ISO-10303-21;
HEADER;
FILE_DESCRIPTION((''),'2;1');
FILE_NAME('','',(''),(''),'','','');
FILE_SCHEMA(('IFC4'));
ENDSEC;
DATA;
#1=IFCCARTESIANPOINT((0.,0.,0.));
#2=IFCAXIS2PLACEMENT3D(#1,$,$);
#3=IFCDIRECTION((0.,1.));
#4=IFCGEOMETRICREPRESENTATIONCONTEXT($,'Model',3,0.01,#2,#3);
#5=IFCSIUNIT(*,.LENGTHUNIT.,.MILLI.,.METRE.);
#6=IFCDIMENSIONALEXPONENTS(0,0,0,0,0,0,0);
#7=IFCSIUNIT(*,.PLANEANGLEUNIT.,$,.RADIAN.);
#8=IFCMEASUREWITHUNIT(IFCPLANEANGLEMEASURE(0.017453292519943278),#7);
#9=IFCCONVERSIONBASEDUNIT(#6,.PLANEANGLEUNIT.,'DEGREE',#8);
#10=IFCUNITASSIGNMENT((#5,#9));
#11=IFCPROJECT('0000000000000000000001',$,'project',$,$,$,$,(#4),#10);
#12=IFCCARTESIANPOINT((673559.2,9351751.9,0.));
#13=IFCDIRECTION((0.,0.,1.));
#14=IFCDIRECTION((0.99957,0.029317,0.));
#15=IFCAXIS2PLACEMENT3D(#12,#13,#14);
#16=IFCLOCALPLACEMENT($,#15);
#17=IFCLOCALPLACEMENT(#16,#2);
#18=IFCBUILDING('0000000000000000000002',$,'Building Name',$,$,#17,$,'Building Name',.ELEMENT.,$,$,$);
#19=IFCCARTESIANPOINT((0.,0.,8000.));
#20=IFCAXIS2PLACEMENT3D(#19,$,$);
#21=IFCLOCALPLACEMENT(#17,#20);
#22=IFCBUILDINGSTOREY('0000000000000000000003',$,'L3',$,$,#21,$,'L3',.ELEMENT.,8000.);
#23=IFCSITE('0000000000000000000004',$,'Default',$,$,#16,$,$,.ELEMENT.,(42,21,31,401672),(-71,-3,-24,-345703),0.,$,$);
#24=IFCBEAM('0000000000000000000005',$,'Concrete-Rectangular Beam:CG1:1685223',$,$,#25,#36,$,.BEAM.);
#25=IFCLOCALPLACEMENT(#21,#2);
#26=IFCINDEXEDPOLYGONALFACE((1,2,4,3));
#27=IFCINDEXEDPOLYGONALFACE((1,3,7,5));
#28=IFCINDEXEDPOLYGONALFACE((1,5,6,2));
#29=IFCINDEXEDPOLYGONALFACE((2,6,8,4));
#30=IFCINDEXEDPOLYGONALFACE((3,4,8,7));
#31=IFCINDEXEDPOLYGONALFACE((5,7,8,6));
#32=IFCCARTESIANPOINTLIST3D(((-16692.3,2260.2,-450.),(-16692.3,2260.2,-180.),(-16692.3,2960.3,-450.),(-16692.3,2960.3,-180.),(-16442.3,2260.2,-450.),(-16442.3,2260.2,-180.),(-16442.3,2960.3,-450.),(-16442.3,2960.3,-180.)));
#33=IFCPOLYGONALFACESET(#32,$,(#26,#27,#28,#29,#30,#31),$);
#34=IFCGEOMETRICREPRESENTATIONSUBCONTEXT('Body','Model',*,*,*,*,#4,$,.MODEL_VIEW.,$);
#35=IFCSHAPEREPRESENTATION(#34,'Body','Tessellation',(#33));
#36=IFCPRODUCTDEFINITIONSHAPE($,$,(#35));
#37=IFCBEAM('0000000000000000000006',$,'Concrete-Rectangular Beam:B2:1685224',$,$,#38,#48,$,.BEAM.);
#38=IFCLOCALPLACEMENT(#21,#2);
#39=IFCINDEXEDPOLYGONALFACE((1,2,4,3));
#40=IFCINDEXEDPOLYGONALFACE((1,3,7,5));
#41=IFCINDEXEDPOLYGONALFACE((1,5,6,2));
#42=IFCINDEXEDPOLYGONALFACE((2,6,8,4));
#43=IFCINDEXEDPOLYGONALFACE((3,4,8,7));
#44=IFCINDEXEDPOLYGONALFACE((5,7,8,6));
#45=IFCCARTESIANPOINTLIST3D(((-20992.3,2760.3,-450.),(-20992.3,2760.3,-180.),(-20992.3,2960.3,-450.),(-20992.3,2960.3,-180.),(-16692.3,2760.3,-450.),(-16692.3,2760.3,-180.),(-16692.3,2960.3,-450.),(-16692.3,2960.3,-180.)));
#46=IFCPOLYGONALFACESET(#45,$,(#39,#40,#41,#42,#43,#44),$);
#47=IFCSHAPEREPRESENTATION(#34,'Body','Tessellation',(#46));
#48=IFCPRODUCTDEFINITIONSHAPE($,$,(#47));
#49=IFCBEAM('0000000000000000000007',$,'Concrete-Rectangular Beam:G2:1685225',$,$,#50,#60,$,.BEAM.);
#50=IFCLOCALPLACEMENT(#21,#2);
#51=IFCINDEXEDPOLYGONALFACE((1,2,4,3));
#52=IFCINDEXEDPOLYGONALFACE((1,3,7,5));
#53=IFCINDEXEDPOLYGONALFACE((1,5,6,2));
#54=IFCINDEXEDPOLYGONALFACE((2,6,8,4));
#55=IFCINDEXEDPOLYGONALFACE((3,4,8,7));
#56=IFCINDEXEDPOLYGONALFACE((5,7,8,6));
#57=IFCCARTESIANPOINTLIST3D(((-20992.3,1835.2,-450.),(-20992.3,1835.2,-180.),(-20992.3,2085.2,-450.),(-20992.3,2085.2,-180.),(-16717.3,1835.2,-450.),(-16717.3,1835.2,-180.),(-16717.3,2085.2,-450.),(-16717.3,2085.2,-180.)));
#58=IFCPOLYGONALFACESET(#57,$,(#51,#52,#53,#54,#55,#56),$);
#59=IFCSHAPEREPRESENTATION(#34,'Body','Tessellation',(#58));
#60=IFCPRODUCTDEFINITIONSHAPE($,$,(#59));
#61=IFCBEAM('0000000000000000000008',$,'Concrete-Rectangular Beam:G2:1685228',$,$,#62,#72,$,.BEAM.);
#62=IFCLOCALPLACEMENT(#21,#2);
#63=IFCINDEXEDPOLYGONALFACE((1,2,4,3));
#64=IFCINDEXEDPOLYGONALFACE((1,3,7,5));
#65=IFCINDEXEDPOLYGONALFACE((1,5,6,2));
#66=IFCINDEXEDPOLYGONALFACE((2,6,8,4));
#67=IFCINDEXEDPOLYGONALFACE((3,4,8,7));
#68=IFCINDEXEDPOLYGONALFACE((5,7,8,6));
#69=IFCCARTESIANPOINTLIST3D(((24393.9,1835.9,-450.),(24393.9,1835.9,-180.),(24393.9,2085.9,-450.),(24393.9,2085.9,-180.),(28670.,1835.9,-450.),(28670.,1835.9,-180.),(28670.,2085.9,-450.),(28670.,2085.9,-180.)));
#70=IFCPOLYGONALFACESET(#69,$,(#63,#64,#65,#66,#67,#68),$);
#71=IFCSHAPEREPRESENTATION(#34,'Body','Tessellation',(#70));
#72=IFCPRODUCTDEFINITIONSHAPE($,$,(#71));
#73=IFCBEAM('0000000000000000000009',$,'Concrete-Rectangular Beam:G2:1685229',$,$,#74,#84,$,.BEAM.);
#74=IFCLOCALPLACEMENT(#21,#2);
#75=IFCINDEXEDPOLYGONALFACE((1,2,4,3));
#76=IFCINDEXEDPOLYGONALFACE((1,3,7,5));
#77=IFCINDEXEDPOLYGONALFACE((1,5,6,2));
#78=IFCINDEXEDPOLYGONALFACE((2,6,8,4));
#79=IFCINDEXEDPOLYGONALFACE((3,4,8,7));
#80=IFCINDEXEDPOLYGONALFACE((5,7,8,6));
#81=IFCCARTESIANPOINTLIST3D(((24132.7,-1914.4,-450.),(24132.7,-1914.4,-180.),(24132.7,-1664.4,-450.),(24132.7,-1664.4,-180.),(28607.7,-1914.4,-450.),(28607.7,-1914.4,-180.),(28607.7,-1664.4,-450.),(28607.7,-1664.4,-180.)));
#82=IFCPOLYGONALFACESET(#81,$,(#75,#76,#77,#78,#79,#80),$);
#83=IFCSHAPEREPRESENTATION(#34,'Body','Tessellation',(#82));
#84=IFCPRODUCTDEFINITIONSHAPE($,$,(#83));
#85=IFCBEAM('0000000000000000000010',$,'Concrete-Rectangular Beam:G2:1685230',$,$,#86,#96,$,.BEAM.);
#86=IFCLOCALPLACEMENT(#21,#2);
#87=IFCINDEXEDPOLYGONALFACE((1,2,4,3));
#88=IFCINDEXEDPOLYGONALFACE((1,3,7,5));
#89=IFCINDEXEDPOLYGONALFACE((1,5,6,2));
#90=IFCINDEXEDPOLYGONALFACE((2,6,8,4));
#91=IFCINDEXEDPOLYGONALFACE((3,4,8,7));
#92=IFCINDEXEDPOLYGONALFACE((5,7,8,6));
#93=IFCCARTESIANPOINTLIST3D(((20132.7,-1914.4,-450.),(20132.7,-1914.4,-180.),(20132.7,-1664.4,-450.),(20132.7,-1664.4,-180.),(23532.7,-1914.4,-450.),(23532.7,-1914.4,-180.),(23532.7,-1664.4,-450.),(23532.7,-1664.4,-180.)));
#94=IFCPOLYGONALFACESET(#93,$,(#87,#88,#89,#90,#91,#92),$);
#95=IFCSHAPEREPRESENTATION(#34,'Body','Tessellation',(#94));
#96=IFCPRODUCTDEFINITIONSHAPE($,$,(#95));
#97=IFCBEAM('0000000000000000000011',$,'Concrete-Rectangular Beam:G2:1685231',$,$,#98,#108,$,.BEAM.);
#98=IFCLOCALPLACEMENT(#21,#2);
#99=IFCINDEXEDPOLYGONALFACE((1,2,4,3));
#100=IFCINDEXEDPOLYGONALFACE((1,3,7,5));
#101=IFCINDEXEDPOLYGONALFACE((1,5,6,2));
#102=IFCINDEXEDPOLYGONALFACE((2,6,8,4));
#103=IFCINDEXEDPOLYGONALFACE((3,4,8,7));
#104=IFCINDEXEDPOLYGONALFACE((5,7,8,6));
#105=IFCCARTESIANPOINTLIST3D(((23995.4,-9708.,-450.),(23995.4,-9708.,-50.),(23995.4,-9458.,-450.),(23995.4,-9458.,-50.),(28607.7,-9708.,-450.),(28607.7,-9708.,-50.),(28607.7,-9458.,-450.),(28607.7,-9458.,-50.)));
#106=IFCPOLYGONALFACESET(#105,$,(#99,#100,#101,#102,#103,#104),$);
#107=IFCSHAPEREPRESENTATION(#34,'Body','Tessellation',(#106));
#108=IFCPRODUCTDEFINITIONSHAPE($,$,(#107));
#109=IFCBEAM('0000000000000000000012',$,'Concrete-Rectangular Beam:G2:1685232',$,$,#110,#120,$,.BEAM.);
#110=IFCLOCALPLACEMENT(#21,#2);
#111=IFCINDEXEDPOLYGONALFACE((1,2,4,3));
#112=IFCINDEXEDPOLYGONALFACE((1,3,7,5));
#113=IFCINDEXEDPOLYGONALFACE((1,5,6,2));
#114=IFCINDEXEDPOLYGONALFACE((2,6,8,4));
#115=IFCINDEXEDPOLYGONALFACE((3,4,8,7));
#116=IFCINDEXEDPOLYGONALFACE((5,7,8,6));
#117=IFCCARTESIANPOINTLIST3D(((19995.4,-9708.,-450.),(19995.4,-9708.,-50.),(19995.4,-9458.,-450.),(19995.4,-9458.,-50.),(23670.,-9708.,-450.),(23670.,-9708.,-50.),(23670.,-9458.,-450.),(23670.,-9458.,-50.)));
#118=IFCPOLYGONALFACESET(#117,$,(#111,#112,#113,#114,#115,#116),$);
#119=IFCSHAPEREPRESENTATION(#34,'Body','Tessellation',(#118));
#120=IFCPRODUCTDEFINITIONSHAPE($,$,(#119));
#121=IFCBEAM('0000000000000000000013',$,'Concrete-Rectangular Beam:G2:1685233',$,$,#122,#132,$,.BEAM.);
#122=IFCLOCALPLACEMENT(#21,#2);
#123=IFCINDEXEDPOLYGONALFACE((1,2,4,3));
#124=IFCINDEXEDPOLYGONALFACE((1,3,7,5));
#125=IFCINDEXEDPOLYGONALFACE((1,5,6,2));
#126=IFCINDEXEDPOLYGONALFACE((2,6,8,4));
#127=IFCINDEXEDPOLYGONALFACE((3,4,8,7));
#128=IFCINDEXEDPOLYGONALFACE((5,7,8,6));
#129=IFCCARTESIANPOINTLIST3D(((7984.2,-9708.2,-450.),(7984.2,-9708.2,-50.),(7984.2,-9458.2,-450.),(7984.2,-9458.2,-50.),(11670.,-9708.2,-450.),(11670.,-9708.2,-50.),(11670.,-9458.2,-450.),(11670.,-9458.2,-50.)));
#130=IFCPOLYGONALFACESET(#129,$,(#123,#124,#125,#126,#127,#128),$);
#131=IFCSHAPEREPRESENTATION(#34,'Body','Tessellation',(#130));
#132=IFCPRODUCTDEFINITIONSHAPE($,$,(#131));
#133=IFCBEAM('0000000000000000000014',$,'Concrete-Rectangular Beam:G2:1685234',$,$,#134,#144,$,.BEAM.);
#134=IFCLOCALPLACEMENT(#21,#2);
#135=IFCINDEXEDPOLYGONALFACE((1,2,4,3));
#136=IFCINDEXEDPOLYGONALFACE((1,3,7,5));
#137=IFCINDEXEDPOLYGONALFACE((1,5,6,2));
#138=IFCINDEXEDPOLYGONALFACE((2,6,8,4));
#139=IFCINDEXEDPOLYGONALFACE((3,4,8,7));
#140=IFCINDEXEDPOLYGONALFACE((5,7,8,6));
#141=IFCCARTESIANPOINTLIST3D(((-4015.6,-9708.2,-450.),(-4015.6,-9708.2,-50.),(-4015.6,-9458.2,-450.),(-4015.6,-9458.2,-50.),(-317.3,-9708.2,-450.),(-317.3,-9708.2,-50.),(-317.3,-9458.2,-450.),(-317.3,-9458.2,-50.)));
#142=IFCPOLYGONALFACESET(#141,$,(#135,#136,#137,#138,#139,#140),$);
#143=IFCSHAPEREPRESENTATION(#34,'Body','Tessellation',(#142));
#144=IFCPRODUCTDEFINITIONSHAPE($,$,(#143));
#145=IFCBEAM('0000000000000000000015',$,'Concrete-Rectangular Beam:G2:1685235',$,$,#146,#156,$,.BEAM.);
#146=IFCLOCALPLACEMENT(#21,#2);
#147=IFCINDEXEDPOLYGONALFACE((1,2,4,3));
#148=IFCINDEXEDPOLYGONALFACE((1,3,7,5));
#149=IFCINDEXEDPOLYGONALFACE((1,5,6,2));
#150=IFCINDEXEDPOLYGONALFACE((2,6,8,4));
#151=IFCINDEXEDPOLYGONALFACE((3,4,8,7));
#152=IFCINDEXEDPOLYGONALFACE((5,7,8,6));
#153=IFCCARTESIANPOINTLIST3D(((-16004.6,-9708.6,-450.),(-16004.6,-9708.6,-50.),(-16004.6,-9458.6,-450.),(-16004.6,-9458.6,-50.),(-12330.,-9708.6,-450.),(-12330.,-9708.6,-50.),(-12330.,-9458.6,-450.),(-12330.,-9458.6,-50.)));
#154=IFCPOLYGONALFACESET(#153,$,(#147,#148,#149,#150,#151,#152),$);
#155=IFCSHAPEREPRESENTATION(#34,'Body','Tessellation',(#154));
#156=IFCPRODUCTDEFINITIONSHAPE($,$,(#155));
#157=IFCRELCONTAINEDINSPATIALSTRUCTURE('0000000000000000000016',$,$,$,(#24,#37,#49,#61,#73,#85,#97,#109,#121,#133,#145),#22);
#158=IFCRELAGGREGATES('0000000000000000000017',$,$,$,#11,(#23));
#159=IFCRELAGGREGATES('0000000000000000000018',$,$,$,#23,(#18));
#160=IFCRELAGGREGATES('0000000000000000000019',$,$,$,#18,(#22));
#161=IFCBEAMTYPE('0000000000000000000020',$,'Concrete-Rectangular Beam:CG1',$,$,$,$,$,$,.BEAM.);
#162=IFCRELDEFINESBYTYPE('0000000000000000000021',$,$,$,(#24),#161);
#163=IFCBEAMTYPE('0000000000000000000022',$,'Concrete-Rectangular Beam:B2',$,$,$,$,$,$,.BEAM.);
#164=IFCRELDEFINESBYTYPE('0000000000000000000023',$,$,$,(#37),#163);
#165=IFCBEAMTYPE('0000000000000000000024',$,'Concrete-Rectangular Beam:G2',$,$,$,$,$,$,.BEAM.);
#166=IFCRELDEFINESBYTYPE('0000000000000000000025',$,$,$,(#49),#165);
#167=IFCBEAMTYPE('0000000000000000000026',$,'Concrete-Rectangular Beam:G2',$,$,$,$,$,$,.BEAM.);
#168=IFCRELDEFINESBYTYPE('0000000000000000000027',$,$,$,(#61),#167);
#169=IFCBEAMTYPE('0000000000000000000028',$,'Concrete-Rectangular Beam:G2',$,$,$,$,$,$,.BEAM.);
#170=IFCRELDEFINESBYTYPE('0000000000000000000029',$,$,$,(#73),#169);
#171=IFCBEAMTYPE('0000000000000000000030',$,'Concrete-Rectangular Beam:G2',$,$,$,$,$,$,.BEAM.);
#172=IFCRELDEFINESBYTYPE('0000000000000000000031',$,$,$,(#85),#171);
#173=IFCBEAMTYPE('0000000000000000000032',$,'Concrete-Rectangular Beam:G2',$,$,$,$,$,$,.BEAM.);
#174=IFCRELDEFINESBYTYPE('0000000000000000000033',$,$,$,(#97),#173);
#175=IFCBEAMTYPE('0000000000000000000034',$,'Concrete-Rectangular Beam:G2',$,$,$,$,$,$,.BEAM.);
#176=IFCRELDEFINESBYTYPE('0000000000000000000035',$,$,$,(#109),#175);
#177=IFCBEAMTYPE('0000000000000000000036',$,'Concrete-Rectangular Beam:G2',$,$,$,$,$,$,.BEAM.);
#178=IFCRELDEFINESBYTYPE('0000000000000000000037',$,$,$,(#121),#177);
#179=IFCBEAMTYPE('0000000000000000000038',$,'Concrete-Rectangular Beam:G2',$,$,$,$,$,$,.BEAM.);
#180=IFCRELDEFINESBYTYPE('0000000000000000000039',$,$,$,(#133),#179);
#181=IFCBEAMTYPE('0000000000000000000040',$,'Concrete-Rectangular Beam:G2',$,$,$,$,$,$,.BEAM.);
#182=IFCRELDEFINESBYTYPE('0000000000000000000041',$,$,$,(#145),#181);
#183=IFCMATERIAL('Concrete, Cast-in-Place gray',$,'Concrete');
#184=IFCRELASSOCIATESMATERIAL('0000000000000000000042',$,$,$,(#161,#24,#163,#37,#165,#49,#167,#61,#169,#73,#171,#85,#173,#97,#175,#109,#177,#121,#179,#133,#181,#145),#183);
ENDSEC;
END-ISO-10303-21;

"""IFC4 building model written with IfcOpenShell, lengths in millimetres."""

from ifc_helpers import new_model, entity, si_unit, converted_unit, direction, frame, origin, place, context, subcontext, project, spatial, indexed_curve, outline, extrude, source, transform, mapped, material, type_object, type_shapes, element, save


model = new_model("IFC4")

# Units and contexts
model_context = context("Model", 3, precision=0.01, world=origin(), true_north=direction((0.0, 1.0)))
body_context = subcontext(model_context, "Body", "Model", "MODEL_VIEW")
ifc_project = project(units=[si_unit("LENGTHUNIT", "METRE", prefix="MILLI"), converted_unit("PLANEANGLEUNIT", "DEGREE", entity("IfcPlaneAngleMeasure", 0.017453292519943278), si_unit("PLANEANGLEUNIT", "RADIAN"), dimensions=[0, 0, 0, 0, 0, 0, 0])], contexts=[model_context])

# Site, building, storey
site_placement = place(None, frame((673559.2, 9351751.9, 0.0), z_axis=(0.0, 0.0, 1.0), x_axis=(0.99957, 0.029317, 0.0)))
site = spatial("IfcSite", under=ifc_project, at=site_placement, Name="Default", CompositionType="ELEMENT", RefLatitude=(42, 21, 31, 401672), RefLongitude=(-71, -3, -24, -345703), RefElevation=0.0)
building_placement = place(site_placement, origin())
building = spatial("IfcBuilding", under=site, at=building_placement, Name="Building Name", LongName="Building Name", CompositionType="ELEMENT")
storey_placement = place(building_placement, frame((0.0, 0.0, 8000.0)))
storey = spatial("IfcBuildingStorey", under=building, at=storey_placement, Name="L3", LongName="L3", CompositionType="ELEMENT", Elevation=8000.0)

# Shared definitions
ifc_material = material(Name="Concrete, Cast-in-Place gray", Category="Concrete")

# Beams
beam_type_1 = type_object("IfcBeamType", Name="Concrete-Rectangular Beam:CG1", PredefinedType="BEAM", material=ifc_material)
shared_shape_1 = source(origin(), body_context, "Body", "SweptSolid", [
    extrude(outline(indexed_curve([(-125.0, -135.0), (125.0, -135.0), (125.0, 135.0), (-125.0, 135.0), (-125.0, -135.0)], self_intersect=False)), frame((-16567.3, 2260.2, 7685.0), z_axis=(0.0, 1.0, 0.0), x_axis=(-1.0, 0.0, 0.0)), (0.0, 0.0, 1.0), 700.1),
])
type_shapes(beam_type_1, [shared_shape_1])
beam_1_placement = place(storey_placement, frame((0.0, 0.0, -8000.0)))
element("IfcBeam", 1, at=beam_1_placement, inside=storey, type_object=beam_type_1, material=ifc_material, Name="Concrete-Rectangular Beam:CG1:1685223", PredefinedType="BEAM", context=body_context, shape_type="MappedRepresentation", body=[
    mapped(shared_shape_1, transform((0.0, 0.0, 0.0), scale=1.0)),
])
beam_type_2 = type_object("IfcBeamType", Name="Concrete-Rectangular Beam:B2", PredefinedType="BEAM", material=ifc_material)
shared_shape_2 = source(origin(), body_context, "Body", "SweptSolid", [
    extrude(outline(indexed_curve([(-135.0, -100.0), (135.0, -100.0), (135.0, 100.0), (-135.0, 100.0), (-135.0, -100.0)], self_intersect=False)), frame((-20992.3, 2860.3, 7685.0), z_axis=(1.0, 0.0, 0.0), x_axis=(0.0, 0.0, -1.0)), (0.0, 0.0, 1.0), 4300.0),
])
type_shapes(beam_type_2, [shared_shape_2])
beam_2_placement = place(storey_placement, frame((0.0, 0.0, -8000.0)))
element("IfcBeam", 2, at=beam_2_placement, inside=storey, type_object=beam_type_2, material=ifc_material, Name="Concrete-Rectangular Beam:B2:1685224", PredefinedType="BEAM", context=body_context, shape_type="MappedRepresentation", body=[
    mapped(shared_shape_2, transform((0.0, 0.0, 0.0), scale=1.0)),
])
beam_type_3 = type_object("IfcBeamType", Name="Concrete-Rectangular Beam:G2", PredefinedType="BEAM", material=ifc_material)
shared_shape_3 = source(origin(), body_context, "Body", "SweptSolid", [
    extrude(outline(indexed_curve([(-135.0, -125.0), (135.0, -125.0), (135.0, 125.0), (-135.0, 125.0), (-135.0, -125.0)], self_intersect=False)), frame((-20992.3, 1960.2, 7685.0), z_axis=(1.0, 0.0, 0.0), x_axis=(0.0, 0.0, -1.0)), (0.0, 0.0, 1.0), 4275.0),
])
type_shapes(beam_type_3, [shared_shape_3])
beam_3_placement = place(storey_placement, frame((0.0, 0.0, -8000.0)))
element("IfcBeam", 3, at=beam_3_placement, inside=storey, type_object=beam_type_3, material=ifc_material, Name="Concrete-Rectangular Beam:G2:1685225", PredefinedType="BEAM", context=body_context, shape_type="MappedRepresentation", body=[
    mapped(shared_shape_3, transform((0.0, 0.0, 0.0), scale=1.0)),
])
beam_type_4 = type_object("IfcBeamType", Name="Concrete-Rectangular Beam:G2", PredefinedType="BEAM", material=ifc_material)
shared_shape_4 = source(origin(), body_context, "Body", "SweptSolid", [
    extrude(outline(indexed_curve([(-135.0, -125.0), (135.0, -125.0), (135.0, 125.0), (-135.0, 125.0), (-135.0, -125.0)], self_intersect=False)), frame((28670.0, 1960.9, 7685.0), z_axis=(-1.0, 0.0, 0.0), x_axis=(0.0, 0.0, -1.0)), (0.0, 0.0, 1.0), 4276.1),
])
type_shapes(beam_type_4, [shared_shape_4])
beam_4_placement = place(storey_placement, frame((0.0, 0.0, -8000.0)))
element("IfcBeam", 4, at=beam_4_placement, inside=storey, type_object=beam_type_4, material=ifc_material, Name="Concrete-Rectangular Beam:G2:1685228", PredefinedType="BEAM", context=body_context, shape_type="MappedRepresentation", body=[
    mapped(shared_shape_4, transform((0.0, 0.0, 0.0), scale=1.0)),
])
beam_type_5 = type_object("IfcBeamType", Name="Concrete-Rectangular Beam:G2", PredefinedType="BEAM", material=ifc_material)
shared_shape_5 = source(origin(), body_context, "Body", "SweptSolid", [
    extrude(outline(indexed_curve([(-135.0, -125.0), (135.0, -125.0), (135.0, 125.0), (-135.0, 125.0), (-135.0, -125.0)], self_intersect=False)), frame((28607.7, -1789.4, 7685.0), z_axis=(-1.0, 0.0, 0.0), x_axis=(0.0, 0.0, -1.0)), (0.0, 0.0, 1.0), 4475.0),
])
type_shapes(beam_type_5, [shared_shape_5])
beam_5_placement = place(storey_placement, frame((0.0, 0.0, -8000.0)))
element("IfcBeam", 5, at=beam_5_placement, inside=storey, type_object=beam_type_5, material=ifc_material, Name="Concrete-Rectangular Beam:G2:1685229", PredefinedType="BEAM", context=body_context, shape_type="MappedRepresentation", body=[
    mapped(shared_shape_5, transform((0.0, 0.0, 0.0), scale=1.0)),
])
beam_type_6 = type_object("IfcBeamType", Name="Concrete-Rectangular Beam:G2", PredefinedType="BEAM", material=ifc_material)
shared_shape_6 = source(origin(), body_context, "Body", "SweptSolid", [
    extrude(outline(indexed_curve([(-135.0, -125.0), (135.0, -125.0), (135.0, 125.0), (-135.0, 125.0), (-135.0, -125.0)], self_intersect=False)), frame((23532.7, -1789.4, 7685.0), z_axis=(-1.0, 0.0, 0.0), x_axis=(0.0, 0.0, -1.0)), (0.0, 0.0, 1.0), 3400.0),
])
type_shapes(beam_type_6, [shared_shape_6])
beam_6_placement = place(storey_placement, frame((0.0, 0.0, -8000.0)))
element("IfcBeam", 6, at=beam_6_placement, inside=storey, type_object=beam_type_6, material=ifc_material, Name="Concrete-Rectangular Beam:G2:1685230", PredefinedType="BEAM", context=body_context, shape_type="MappedRepresentation", body=[
    mapped(shared_shape_6, transform((0.0, 0.0, 0.0), scale=1.0)),
])
beam_type_7 = type_object("IfcBeamType", Name="Concrete-Rectangular Beam:G2", PredefinedType="BEAM", material=ifc_material)
shared_shape_7 = source(origin(), body_context, "Body", "SweptSolid", [
    extrude(outline(indexed_curve([(-200.0, -125.0), (200.0, -125.0), (200.0, 125.0), (-200.0, 125.0), (-200.0, -125.0)], self_intersect=False)), frame((28607.7, -9583.0, 7750.0), z_axis=(-1.0, 0.0, 0.0), x_axis=(0.0, 0.0, -1.0)), (0.0, 0.0, 1.0), 4612.3),
])
type_shapes(beam_type_7, [shared_shape_7])
beam_7_placement = place(storey_placement, frame((0.0, 0.0, -8000.0)))
element("IfcBeam", 7, at=beam_7_placement, inside=storey, type_object=beam_type_7, material=ifc_material, Name="Concrete-Rectangular Beam:G2:1685231", PredefinedType="BEAM", context=body_context, shape_type="MappedRepresentation", body=[
    mapped(shared_shape_7, transform((0.0, 0.0, 0.0), scale=1.0)),
])
beam_type_8 = type_object("IfcBeamType", Name="Concrete-Rectangular Beam:G2", PredefinedType="BEAM", material=ifc_material)
shared_shape_8 = source(origin(), body_context, "Body", "SweptSolid", [
    extrude(outline(indexed_curve([(-200.0, -125.0), (200.0, -125.0), (200.0, 125.0), (-200.0, 125.0), (-200.0, -125.0)], self_intersect=False)), frame((23670.0, -9583.0, 7750.0), z_axis=(-1.0, 0.0, 0.0), x_axis=(0.0, 0.0, -1.0)), (0.0, 0.0, 1.0), 3674.6),
])
type_shapes(beam_type_8, [shared_shape_8])
beam_8_placement = place(storey_placement, frame((0.0, 0.0, -8000.0)))
element("IfcBeam", 8, at=beam_8_placement, inside=storey, type_object=beam_type_8, material=ifc_material, Name="Concrete-Rectangular Beam:G2:1685232", PredefinedType="BEAM", context=body_context, shape_type="MappedRepresentation", body=[
    mapped(shared_shape_8, transform((0.0, 0.0, 0.0), scale=1.0)),
])
beam_type_9 = type_object("IfcBeamType", Name="Concrete-Rectangular Beam:G2", PredefinedType="BEAM", material=ifc_material)
shared_shape_9 = source(origin(), body_context, "Body", "SweptSolid", [
    extrude(outline(indexed_curve([(-200.0, -125.0), (200.0, -125.0), (200.0, 125.0), (-200.0, 125.0), (-200.0, -125.0)], self_intersect=False)), frame((11670.0, -9583.2, 7750.0), z_axis=(-1.0, 0.0, 0.0), x_axis=(0.0, 0.0, -1.0)), (0.0, 0.0, 1.0), 3685.8),
])
type_shapes(beam_type_9, [shared_shape_9])
beam_9_placement = place(storey_placement, frame((0.0, 0.0, -8000.0)))
element("IfcBeam", 9, at=beam_9_placement, inside=storey, type_object=beam_type_9, material=ifc_material, Name="Concrete-Rectangular Beam:G2:1685233", PredefinedType="BEAM", context=body_context, shape_type="MappedRepresentation", body=[
    mapped(shared_shape_9, transform((0.0, 0.0, 0.0), scale=1.0)),
])
beam_type_10 = type_object("IfcBeamType", Name="Concrete-Rectangular Beam:G2", PredefinedType="BEAM", material=ifc_material)
shared_shape_10 = source(origin(), body_context, "Body", "SweptSolid", [
    extrude(outline(indexed_curve([(-200.0, -125.0), (200.0, -125.0), (200.0, 125.0), (-200.0, 125.0), (-200.0, -125.0)], self_intersect=False)), frame((-317.3, -9583.2, 7750.0), z_axis=(-1.0, 0.0, 0.0), x_axis=(0.0, 0.0, -1.0)), (0.0, 0.0, 1.0), 3698.2),
])
type_shapes(beam_type_10, [shared_shape_10])
beam_10_placement = place(storey_placement, frame((0.0, 0.0, -8000.0)))
element("IfcBeam", 10, at=beam_10_placement, inside=storey, type_object=beam_type_10, material=ifc_material, Name="Concrete-Rectangular Beam:G2:1685234", PredefinedType="BEAM", context=body_context, shape_type="MappedRepresentation", body=[
    mapped(shared_shape_10, transform((0.0, 0.0, 0.0), scale=1.0)),
])
beam_type_11 = type_object("IfcBeamType", Name="Concrete-Rectangular Beam:G2", PredefinedType="BEAM", material=ifc_material)
shared_shape_11 = source(origin(), body_context, "Body", "SweptSolid", [
    extrude(outline(indexed_curve([(-200.0, -125.0), (200.0, -125.0), (200.0, 125.0), (-200.0, 125.0), (-200.0, -125.0)], self_intersect=False)), frame((-12330.0, -9583.6, 7750.0), z_axis=(-1.0, 0.0, 0.0), x_axis=(0.0, 0.0, -1.0)), (0.0, 0.0, 1.0), 3674.6),
])
type_shapes(beam_type_11, [shared_shape_11])
beam_11_placement = place(storey_placement, frame((0.0, 0.0, -8000.0)))
element("IfcBeam", 11, at=beam_11_placement, inside=storey, type_object=beam_type_11, material=ifc_material, Name="Concrete-Rectangular Beam:G2:1685235", PredefinedType="BEAM", context=body_context, shape_type="MappedRepresentation", body=[
    mapped(shared_shape_11, transform((0.0, 0.0, 0.0), scale=1.0)),
])

save(model, "model.ifc")
